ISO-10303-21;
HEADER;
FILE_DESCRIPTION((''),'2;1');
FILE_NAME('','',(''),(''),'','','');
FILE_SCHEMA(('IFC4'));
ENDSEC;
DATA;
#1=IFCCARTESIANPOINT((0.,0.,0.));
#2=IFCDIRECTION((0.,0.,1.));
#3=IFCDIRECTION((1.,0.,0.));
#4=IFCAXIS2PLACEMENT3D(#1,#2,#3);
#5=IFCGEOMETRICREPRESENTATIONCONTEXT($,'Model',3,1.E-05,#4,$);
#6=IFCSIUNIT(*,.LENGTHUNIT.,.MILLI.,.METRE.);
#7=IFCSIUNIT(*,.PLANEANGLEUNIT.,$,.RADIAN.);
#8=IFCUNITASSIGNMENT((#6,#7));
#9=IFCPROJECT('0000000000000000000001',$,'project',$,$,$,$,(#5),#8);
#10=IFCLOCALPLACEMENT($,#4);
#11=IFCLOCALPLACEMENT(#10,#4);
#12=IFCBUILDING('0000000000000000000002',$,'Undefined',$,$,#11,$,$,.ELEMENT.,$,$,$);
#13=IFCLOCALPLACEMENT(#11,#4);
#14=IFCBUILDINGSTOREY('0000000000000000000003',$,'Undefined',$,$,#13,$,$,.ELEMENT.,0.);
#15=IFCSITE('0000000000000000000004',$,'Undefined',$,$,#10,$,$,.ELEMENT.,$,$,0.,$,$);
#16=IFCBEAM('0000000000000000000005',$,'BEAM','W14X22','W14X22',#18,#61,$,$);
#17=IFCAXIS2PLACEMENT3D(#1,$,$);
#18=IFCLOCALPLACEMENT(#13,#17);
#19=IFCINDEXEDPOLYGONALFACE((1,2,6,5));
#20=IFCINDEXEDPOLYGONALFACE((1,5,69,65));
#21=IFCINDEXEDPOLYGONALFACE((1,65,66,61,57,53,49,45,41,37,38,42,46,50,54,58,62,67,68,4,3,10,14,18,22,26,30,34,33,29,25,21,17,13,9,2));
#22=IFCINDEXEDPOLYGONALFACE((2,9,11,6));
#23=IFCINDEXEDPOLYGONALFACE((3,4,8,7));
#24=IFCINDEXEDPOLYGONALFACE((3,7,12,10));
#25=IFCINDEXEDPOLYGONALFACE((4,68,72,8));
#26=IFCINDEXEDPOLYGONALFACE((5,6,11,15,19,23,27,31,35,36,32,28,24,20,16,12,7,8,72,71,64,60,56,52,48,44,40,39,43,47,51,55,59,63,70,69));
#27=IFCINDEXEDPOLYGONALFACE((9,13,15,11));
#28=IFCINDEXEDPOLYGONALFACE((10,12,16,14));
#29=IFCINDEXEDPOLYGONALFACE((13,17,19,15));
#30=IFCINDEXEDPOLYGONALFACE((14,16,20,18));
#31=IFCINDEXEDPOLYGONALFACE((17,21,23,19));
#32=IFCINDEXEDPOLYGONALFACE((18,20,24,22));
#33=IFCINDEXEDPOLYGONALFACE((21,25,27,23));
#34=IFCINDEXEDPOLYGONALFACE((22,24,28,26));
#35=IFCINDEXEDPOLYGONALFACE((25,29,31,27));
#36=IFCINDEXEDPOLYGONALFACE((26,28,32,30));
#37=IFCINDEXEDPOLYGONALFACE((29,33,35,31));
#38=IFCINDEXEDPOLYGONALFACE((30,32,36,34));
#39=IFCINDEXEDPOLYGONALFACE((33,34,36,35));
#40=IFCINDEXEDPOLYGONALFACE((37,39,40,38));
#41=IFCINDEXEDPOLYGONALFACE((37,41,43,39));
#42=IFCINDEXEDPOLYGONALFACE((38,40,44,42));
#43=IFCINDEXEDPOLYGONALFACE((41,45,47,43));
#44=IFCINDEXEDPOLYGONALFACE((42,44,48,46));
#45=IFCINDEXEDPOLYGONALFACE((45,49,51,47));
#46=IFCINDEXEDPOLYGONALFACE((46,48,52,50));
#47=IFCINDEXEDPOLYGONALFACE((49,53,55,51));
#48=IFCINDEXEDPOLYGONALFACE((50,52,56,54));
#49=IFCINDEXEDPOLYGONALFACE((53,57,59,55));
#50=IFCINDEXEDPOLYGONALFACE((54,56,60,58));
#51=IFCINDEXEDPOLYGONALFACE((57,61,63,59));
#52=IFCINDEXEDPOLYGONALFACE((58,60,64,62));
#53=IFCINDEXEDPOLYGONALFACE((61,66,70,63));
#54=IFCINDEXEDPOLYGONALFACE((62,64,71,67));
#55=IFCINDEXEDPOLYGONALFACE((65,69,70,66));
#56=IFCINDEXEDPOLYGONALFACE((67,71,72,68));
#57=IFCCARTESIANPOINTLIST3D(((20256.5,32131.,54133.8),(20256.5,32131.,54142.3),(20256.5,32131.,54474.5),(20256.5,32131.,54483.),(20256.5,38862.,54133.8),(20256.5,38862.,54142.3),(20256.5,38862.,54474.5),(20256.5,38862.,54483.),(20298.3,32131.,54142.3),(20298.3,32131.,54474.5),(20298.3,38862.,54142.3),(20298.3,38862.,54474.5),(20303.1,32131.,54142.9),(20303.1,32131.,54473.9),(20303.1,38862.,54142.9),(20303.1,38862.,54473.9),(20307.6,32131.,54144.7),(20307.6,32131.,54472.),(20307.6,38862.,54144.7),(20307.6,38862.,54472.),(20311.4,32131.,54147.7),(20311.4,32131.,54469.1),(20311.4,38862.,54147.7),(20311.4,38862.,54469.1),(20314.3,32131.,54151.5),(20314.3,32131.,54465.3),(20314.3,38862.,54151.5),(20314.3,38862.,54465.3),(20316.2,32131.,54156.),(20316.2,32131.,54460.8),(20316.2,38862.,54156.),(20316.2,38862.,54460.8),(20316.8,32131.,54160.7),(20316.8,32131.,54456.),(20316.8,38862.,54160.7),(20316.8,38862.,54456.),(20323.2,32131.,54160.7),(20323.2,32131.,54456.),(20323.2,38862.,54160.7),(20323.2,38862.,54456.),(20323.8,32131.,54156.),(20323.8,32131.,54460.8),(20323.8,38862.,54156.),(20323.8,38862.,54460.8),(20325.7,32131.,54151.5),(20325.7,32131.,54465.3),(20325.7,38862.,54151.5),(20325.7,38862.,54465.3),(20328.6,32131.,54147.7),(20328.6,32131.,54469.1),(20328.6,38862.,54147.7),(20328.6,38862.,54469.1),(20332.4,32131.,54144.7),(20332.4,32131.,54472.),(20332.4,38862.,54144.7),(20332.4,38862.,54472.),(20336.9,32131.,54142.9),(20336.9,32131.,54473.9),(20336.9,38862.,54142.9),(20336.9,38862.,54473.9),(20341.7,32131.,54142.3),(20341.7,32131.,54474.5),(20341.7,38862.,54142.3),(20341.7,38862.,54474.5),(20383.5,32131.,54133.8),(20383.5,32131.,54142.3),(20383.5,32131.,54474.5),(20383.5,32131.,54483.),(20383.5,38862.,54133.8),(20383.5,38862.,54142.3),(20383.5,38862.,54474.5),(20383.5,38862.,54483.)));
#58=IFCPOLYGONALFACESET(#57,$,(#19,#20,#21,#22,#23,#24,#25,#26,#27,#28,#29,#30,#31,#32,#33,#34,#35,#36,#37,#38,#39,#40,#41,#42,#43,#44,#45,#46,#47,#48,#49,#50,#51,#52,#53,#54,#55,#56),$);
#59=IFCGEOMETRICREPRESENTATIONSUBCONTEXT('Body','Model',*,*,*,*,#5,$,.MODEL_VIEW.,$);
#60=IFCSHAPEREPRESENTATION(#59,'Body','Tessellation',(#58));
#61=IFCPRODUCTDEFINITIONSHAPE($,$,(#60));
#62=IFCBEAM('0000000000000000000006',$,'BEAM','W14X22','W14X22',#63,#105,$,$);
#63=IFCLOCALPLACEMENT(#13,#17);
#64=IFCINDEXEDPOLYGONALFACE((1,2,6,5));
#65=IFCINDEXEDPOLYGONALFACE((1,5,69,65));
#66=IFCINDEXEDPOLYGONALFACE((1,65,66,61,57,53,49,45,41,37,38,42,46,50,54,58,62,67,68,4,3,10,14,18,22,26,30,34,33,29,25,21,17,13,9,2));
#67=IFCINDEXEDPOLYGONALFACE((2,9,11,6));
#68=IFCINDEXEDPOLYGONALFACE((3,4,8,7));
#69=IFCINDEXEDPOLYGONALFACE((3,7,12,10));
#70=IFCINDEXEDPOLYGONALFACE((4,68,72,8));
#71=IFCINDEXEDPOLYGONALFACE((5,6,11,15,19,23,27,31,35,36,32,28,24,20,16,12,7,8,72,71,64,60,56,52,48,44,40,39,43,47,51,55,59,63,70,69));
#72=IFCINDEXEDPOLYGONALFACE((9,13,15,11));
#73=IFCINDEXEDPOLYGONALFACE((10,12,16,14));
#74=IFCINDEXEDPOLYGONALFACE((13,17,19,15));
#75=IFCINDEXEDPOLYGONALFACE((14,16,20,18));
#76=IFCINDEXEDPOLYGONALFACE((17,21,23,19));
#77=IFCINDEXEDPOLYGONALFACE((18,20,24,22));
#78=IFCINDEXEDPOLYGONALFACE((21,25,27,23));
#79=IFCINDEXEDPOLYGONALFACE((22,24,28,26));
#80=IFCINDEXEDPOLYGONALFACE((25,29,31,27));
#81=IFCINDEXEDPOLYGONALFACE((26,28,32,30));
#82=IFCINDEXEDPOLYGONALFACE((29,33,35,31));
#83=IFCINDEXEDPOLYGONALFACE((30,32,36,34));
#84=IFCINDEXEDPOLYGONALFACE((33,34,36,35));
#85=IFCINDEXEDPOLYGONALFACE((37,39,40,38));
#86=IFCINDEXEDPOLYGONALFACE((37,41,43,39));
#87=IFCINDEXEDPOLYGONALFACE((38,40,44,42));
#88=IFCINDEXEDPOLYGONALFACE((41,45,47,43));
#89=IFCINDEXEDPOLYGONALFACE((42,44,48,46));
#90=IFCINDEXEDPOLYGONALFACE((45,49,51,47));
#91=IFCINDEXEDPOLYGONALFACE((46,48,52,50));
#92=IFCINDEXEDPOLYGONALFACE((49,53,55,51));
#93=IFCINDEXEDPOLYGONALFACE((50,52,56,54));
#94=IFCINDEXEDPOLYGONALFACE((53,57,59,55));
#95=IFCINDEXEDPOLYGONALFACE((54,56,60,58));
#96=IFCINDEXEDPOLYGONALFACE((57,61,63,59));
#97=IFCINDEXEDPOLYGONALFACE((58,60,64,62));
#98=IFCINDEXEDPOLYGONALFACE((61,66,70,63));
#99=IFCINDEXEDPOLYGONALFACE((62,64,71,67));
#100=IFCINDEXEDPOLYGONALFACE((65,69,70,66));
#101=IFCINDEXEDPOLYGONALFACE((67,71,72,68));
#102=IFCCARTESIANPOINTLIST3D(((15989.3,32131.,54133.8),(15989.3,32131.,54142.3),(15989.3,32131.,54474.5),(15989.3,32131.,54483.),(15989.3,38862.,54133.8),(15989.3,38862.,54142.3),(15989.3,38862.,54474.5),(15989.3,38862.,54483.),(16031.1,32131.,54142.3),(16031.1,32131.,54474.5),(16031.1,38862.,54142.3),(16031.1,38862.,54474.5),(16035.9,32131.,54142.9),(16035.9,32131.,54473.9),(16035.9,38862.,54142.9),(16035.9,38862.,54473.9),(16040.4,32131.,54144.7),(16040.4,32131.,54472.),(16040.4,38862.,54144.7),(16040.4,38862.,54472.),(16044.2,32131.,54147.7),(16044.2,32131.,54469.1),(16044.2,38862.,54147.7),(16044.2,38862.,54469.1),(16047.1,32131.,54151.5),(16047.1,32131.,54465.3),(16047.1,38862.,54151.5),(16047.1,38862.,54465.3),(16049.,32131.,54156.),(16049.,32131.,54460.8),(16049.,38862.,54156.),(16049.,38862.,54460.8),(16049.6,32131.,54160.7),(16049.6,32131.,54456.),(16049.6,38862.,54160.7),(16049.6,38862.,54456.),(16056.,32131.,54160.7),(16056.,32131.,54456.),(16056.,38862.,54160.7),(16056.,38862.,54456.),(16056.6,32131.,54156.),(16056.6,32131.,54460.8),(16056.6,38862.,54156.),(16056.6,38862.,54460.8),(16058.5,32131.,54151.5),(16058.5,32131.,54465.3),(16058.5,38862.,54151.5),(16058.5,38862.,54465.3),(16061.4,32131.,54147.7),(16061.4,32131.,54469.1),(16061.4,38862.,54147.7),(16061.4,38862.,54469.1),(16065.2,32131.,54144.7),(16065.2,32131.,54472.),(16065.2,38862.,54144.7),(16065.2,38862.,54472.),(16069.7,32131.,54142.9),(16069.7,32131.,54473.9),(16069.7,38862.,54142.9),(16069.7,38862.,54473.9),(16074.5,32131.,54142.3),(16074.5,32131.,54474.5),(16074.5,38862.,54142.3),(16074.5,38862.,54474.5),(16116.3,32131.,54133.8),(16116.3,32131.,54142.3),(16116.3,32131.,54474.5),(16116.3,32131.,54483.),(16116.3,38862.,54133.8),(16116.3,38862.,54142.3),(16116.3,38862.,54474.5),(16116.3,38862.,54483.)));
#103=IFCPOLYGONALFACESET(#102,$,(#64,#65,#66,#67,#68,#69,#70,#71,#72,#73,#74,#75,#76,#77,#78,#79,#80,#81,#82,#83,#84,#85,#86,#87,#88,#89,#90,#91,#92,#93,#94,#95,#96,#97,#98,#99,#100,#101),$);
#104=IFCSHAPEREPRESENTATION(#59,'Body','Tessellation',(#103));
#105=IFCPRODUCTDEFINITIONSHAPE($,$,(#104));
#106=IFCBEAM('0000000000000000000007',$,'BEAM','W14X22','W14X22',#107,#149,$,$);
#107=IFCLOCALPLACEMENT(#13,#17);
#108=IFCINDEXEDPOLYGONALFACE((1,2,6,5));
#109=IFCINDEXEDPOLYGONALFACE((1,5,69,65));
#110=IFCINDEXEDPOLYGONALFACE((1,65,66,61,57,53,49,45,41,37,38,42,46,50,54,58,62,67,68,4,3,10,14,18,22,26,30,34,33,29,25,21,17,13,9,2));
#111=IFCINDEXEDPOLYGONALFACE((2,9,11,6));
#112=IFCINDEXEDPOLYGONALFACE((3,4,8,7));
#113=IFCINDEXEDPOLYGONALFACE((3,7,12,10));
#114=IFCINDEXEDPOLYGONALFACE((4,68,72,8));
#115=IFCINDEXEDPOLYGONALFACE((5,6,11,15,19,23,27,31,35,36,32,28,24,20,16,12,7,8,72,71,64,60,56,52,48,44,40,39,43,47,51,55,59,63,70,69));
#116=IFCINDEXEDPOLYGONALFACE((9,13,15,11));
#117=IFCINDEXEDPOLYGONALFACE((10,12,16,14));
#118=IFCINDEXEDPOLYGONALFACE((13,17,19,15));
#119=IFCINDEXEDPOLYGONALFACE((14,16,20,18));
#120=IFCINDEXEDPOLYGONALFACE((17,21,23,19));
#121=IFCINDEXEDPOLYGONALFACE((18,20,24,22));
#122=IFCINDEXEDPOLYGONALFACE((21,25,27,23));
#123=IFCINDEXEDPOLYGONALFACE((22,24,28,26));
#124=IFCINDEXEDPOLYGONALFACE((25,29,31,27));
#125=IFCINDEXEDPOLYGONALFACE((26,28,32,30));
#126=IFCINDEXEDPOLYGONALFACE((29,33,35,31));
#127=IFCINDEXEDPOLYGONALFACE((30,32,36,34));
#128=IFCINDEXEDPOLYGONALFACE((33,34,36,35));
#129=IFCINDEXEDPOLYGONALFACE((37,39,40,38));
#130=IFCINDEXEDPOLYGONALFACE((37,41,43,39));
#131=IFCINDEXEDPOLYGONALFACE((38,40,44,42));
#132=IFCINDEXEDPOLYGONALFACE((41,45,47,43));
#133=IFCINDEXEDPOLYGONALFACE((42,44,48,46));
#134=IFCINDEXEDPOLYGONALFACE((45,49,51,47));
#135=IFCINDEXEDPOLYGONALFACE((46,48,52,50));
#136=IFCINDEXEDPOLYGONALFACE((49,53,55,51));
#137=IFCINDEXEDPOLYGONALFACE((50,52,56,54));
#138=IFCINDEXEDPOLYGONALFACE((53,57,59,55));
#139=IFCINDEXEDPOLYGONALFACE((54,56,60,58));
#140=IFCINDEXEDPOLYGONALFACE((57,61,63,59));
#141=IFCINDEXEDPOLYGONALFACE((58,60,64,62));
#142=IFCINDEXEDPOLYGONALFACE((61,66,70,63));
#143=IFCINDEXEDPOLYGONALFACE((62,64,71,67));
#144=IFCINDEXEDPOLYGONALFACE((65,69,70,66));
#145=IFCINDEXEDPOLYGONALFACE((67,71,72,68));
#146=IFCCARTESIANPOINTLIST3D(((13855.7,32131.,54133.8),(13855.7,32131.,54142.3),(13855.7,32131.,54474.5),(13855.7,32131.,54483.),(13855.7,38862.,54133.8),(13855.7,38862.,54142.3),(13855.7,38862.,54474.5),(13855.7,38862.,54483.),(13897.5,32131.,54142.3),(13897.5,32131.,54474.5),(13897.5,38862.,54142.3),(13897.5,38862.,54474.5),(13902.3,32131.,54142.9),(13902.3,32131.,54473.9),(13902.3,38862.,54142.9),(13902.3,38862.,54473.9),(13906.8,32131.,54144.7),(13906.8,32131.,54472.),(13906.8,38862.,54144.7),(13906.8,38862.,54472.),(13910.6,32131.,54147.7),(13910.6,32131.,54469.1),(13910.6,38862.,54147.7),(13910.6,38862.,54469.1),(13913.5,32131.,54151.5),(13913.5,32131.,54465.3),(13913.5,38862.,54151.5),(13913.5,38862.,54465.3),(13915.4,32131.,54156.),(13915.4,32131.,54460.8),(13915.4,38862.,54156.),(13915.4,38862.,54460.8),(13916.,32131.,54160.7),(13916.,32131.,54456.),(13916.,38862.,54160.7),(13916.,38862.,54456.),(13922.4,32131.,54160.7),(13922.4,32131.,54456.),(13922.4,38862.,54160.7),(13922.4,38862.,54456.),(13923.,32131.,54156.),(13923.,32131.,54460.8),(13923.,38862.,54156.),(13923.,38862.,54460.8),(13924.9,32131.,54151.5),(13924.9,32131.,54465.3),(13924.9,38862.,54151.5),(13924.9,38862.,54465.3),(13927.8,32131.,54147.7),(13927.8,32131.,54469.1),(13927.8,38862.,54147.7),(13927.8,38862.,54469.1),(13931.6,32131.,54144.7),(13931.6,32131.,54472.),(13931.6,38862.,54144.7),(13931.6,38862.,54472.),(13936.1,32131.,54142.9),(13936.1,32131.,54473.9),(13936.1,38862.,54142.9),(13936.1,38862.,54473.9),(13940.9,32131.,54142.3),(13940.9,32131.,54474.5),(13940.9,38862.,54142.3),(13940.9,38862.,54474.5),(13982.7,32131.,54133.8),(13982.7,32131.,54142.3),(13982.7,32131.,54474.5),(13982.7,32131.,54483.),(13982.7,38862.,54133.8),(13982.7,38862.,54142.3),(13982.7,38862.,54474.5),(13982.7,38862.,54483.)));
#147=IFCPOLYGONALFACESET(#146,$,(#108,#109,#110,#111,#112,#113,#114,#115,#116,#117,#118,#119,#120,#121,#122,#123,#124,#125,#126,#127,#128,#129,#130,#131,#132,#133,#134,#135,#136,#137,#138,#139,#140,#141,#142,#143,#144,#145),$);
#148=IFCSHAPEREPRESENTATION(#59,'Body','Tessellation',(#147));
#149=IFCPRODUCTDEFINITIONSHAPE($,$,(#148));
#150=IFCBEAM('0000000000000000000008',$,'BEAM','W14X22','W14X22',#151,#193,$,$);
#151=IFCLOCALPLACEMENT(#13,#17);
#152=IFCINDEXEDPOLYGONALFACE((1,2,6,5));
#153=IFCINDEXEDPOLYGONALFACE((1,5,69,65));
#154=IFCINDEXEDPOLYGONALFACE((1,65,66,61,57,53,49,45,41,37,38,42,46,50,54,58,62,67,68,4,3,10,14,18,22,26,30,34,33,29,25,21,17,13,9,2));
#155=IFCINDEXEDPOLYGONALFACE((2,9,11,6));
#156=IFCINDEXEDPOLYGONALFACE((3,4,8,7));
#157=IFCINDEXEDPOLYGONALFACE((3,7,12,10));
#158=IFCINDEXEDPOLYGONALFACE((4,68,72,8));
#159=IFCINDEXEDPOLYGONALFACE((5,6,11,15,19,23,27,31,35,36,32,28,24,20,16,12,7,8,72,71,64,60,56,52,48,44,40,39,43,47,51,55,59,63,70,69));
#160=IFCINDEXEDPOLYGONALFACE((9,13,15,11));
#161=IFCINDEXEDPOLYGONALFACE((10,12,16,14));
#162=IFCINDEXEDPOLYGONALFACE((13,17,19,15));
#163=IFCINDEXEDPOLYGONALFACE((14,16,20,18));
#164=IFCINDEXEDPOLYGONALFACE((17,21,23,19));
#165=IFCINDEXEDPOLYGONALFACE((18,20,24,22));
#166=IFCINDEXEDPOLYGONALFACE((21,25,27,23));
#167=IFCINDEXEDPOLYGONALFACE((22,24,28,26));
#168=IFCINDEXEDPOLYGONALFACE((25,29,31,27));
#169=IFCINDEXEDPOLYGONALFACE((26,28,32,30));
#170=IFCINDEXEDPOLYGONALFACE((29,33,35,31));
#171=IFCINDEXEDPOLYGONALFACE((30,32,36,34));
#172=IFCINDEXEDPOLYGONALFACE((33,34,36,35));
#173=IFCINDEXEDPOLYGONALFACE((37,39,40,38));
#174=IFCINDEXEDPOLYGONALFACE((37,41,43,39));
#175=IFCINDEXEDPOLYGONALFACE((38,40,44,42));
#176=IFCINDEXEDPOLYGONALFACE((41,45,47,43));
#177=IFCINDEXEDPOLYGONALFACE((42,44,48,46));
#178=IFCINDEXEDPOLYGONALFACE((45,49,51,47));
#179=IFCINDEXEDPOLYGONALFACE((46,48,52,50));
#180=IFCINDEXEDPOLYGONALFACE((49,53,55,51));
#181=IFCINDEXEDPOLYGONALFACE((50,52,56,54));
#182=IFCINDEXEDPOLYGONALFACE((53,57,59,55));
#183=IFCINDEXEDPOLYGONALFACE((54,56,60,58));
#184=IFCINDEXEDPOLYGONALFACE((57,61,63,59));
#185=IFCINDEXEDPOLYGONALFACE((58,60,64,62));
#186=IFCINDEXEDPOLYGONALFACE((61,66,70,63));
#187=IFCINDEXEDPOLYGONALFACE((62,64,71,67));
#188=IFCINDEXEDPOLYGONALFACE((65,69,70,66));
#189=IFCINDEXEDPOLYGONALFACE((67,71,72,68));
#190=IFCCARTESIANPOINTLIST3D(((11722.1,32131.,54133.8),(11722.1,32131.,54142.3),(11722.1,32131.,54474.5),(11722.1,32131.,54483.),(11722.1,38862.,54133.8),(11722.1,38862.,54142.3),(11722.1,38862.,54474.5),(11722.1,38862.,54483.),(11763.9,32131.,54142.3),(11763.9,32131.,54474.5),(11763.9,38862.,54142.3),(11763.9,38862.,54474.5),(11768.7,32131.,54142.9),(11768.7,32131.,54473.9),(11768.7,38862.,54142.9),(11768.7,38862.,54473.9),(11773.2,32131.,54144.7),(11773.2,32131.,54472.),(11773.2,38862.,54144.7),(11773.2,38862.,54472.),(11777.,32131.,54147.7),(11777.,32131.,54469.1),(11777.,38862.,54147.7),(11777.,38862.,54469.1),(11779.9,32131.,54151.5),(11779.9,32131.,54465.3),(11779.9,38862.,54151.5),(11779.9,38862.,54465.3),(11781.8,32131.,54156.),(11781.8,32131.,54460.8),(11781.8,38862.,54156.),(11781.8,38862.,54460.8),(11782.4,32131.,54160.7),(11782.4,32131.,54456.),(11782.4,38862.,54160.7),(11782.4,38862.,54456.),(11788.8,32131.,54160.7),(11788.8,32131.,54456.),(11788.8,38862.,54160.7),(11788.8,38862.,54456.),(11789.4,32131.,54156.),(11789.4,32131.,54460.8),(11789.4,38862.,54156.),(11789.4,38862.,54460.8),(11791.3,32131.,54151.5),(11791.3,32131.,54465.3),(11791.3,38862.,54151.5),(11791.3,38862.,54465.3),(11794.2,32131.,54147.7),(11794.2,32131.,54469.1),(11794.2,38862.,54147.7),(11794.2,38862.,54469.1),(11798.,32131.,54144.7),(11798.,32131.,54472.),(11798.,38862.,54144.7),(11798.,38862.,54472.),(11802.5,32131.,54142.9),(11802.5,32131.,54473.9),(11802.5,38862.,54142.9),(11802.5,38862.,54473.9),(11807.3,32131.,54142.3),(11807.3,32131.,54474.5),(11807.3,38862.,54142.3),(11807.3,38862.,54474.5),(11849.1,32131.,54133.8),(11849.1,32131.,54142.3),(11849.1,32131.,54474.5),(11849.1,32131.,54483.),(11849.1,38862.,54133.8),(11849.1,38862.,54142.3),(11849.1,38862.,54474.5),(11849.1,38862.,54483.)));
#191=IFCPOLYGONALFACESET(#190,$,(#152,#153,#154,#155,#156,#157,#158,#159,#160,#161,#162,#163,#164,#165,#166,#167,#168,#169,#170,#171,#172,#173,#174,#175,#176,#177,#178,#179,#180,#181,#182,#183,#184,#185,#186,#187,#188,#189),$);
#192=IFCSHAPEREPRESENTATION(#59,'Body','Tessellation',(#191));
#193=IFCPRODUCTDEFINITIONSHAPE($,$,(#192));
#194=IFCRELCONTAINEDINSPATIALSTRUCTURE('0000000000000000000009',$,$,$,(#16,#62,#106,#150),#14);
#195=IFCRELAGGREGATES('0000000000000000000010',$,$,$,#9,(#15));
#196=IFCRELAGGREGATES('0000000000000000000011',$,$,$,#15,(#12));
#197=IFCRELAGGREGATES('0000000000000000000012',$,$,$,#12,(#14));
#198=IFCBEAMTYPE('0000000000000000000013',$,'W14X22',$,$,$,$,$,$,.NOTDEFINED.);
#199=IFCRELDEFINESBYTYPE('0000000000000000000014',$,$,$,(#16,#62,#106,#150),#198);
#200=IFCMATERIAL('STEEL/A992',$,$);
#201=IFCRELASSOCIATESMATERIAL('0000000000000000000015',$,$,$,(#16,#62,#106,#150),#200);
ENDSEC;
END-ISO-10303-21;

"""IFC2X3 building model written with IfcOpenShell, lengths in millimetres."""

from ifc_helpers import new_model, si_unit, frame, origin_with_axes, origin_2d_with_axis, place, context, subcontext, project, spatial, i_section, extrude, material, type_object, element, save


model = new_model("IFC2X3")

# Units and contexts
model_context = context("Model", 3, precision=1e-05, world=origin_with_axes())
body_context = subcontext(model_context, "Body", "Model", "MODEL_VIEW")
ifc_project = project(units=[si_unit("LENGTHUNIT", "METRE", prefix="MILLI"), si_unit("PLANEANGLEUNIT", "RADIAN")], contexts=[model_context])

# Site, building, storey
site_placement = place(None, origin_with_axes())
site = spatial("IfcSite", under=ifc_project, at=site_placement, Name="Undefined", CompositionType="ELEMENT", RefElevation=0.0)
building_placement = place(site_placement, origin_with_axes())
building = spatial("IfcBuilding", under=site, at=building_placement, Name="Undefined", CompositionType="ELEMENT")
storey_placement = place(building_placement, origin_with_axes())
storey = spatial("IfcBuildingStorey", under=building, at=storey_placement, Name="Undefined", CompositionType="ELEMENT", Elevation=0.0)

# Shared definitions
ifc_material_1 = material(Name="STEEL/A992")

# Beams
beam_type_1 = type_object("IfcBeamType", Name="W14X22", PredefinedType="NOTDEFINED")
for number, where, z_axis, x_axis, name in (
    (1, (20320.0, 32131.0, 54308.4), (0.0, 0.0, 1.0), (0.0, 1.0, 0.0), "BEAM"),
    (2, (16052.8, 32131.0, 54308.4), (0.0, 0.0, 1.0), (0.0, 1.0, 0.0), "BEAM"),
    (3, (13919.2, 32131.0, 54308.4), (0.0, 0.0, 1.0), (0.0, 1.0, 0.0), "BEAM"),
    (4, (11785.6, 32131.0, 54308.4), (0.0, 0.0, 1.0), (0.0, 1.0, 0.0), "BEAM"),
):
    element("IfcBeam", number, at=place(storey_placement, frame(where, z_axis=z_axis, x_axis=x_axis)), inside=storey, type_object=beam_type_1, material=ifc_material_1, Name=name, Description="W14X22", ObjectType="W14X22", context=body_context, shape_type="SweptSolid", body=[
        extrude(i_section(OverallWidth=127.0, OverallDepth=349.2, WebThickness=6.3, FlangeThickness=8.5, FilletRadius=18.5, at=origin_2d_with_axis()), frame((6731.0, 0.0, 0.0), z_axis=(-1.0, 0.0, 0.0), x_axis=(0.0, -1.0, 0.0)), (0.0, 0.0, 1.0), 6731.0),
    ])

save(model, "model.ifc")
